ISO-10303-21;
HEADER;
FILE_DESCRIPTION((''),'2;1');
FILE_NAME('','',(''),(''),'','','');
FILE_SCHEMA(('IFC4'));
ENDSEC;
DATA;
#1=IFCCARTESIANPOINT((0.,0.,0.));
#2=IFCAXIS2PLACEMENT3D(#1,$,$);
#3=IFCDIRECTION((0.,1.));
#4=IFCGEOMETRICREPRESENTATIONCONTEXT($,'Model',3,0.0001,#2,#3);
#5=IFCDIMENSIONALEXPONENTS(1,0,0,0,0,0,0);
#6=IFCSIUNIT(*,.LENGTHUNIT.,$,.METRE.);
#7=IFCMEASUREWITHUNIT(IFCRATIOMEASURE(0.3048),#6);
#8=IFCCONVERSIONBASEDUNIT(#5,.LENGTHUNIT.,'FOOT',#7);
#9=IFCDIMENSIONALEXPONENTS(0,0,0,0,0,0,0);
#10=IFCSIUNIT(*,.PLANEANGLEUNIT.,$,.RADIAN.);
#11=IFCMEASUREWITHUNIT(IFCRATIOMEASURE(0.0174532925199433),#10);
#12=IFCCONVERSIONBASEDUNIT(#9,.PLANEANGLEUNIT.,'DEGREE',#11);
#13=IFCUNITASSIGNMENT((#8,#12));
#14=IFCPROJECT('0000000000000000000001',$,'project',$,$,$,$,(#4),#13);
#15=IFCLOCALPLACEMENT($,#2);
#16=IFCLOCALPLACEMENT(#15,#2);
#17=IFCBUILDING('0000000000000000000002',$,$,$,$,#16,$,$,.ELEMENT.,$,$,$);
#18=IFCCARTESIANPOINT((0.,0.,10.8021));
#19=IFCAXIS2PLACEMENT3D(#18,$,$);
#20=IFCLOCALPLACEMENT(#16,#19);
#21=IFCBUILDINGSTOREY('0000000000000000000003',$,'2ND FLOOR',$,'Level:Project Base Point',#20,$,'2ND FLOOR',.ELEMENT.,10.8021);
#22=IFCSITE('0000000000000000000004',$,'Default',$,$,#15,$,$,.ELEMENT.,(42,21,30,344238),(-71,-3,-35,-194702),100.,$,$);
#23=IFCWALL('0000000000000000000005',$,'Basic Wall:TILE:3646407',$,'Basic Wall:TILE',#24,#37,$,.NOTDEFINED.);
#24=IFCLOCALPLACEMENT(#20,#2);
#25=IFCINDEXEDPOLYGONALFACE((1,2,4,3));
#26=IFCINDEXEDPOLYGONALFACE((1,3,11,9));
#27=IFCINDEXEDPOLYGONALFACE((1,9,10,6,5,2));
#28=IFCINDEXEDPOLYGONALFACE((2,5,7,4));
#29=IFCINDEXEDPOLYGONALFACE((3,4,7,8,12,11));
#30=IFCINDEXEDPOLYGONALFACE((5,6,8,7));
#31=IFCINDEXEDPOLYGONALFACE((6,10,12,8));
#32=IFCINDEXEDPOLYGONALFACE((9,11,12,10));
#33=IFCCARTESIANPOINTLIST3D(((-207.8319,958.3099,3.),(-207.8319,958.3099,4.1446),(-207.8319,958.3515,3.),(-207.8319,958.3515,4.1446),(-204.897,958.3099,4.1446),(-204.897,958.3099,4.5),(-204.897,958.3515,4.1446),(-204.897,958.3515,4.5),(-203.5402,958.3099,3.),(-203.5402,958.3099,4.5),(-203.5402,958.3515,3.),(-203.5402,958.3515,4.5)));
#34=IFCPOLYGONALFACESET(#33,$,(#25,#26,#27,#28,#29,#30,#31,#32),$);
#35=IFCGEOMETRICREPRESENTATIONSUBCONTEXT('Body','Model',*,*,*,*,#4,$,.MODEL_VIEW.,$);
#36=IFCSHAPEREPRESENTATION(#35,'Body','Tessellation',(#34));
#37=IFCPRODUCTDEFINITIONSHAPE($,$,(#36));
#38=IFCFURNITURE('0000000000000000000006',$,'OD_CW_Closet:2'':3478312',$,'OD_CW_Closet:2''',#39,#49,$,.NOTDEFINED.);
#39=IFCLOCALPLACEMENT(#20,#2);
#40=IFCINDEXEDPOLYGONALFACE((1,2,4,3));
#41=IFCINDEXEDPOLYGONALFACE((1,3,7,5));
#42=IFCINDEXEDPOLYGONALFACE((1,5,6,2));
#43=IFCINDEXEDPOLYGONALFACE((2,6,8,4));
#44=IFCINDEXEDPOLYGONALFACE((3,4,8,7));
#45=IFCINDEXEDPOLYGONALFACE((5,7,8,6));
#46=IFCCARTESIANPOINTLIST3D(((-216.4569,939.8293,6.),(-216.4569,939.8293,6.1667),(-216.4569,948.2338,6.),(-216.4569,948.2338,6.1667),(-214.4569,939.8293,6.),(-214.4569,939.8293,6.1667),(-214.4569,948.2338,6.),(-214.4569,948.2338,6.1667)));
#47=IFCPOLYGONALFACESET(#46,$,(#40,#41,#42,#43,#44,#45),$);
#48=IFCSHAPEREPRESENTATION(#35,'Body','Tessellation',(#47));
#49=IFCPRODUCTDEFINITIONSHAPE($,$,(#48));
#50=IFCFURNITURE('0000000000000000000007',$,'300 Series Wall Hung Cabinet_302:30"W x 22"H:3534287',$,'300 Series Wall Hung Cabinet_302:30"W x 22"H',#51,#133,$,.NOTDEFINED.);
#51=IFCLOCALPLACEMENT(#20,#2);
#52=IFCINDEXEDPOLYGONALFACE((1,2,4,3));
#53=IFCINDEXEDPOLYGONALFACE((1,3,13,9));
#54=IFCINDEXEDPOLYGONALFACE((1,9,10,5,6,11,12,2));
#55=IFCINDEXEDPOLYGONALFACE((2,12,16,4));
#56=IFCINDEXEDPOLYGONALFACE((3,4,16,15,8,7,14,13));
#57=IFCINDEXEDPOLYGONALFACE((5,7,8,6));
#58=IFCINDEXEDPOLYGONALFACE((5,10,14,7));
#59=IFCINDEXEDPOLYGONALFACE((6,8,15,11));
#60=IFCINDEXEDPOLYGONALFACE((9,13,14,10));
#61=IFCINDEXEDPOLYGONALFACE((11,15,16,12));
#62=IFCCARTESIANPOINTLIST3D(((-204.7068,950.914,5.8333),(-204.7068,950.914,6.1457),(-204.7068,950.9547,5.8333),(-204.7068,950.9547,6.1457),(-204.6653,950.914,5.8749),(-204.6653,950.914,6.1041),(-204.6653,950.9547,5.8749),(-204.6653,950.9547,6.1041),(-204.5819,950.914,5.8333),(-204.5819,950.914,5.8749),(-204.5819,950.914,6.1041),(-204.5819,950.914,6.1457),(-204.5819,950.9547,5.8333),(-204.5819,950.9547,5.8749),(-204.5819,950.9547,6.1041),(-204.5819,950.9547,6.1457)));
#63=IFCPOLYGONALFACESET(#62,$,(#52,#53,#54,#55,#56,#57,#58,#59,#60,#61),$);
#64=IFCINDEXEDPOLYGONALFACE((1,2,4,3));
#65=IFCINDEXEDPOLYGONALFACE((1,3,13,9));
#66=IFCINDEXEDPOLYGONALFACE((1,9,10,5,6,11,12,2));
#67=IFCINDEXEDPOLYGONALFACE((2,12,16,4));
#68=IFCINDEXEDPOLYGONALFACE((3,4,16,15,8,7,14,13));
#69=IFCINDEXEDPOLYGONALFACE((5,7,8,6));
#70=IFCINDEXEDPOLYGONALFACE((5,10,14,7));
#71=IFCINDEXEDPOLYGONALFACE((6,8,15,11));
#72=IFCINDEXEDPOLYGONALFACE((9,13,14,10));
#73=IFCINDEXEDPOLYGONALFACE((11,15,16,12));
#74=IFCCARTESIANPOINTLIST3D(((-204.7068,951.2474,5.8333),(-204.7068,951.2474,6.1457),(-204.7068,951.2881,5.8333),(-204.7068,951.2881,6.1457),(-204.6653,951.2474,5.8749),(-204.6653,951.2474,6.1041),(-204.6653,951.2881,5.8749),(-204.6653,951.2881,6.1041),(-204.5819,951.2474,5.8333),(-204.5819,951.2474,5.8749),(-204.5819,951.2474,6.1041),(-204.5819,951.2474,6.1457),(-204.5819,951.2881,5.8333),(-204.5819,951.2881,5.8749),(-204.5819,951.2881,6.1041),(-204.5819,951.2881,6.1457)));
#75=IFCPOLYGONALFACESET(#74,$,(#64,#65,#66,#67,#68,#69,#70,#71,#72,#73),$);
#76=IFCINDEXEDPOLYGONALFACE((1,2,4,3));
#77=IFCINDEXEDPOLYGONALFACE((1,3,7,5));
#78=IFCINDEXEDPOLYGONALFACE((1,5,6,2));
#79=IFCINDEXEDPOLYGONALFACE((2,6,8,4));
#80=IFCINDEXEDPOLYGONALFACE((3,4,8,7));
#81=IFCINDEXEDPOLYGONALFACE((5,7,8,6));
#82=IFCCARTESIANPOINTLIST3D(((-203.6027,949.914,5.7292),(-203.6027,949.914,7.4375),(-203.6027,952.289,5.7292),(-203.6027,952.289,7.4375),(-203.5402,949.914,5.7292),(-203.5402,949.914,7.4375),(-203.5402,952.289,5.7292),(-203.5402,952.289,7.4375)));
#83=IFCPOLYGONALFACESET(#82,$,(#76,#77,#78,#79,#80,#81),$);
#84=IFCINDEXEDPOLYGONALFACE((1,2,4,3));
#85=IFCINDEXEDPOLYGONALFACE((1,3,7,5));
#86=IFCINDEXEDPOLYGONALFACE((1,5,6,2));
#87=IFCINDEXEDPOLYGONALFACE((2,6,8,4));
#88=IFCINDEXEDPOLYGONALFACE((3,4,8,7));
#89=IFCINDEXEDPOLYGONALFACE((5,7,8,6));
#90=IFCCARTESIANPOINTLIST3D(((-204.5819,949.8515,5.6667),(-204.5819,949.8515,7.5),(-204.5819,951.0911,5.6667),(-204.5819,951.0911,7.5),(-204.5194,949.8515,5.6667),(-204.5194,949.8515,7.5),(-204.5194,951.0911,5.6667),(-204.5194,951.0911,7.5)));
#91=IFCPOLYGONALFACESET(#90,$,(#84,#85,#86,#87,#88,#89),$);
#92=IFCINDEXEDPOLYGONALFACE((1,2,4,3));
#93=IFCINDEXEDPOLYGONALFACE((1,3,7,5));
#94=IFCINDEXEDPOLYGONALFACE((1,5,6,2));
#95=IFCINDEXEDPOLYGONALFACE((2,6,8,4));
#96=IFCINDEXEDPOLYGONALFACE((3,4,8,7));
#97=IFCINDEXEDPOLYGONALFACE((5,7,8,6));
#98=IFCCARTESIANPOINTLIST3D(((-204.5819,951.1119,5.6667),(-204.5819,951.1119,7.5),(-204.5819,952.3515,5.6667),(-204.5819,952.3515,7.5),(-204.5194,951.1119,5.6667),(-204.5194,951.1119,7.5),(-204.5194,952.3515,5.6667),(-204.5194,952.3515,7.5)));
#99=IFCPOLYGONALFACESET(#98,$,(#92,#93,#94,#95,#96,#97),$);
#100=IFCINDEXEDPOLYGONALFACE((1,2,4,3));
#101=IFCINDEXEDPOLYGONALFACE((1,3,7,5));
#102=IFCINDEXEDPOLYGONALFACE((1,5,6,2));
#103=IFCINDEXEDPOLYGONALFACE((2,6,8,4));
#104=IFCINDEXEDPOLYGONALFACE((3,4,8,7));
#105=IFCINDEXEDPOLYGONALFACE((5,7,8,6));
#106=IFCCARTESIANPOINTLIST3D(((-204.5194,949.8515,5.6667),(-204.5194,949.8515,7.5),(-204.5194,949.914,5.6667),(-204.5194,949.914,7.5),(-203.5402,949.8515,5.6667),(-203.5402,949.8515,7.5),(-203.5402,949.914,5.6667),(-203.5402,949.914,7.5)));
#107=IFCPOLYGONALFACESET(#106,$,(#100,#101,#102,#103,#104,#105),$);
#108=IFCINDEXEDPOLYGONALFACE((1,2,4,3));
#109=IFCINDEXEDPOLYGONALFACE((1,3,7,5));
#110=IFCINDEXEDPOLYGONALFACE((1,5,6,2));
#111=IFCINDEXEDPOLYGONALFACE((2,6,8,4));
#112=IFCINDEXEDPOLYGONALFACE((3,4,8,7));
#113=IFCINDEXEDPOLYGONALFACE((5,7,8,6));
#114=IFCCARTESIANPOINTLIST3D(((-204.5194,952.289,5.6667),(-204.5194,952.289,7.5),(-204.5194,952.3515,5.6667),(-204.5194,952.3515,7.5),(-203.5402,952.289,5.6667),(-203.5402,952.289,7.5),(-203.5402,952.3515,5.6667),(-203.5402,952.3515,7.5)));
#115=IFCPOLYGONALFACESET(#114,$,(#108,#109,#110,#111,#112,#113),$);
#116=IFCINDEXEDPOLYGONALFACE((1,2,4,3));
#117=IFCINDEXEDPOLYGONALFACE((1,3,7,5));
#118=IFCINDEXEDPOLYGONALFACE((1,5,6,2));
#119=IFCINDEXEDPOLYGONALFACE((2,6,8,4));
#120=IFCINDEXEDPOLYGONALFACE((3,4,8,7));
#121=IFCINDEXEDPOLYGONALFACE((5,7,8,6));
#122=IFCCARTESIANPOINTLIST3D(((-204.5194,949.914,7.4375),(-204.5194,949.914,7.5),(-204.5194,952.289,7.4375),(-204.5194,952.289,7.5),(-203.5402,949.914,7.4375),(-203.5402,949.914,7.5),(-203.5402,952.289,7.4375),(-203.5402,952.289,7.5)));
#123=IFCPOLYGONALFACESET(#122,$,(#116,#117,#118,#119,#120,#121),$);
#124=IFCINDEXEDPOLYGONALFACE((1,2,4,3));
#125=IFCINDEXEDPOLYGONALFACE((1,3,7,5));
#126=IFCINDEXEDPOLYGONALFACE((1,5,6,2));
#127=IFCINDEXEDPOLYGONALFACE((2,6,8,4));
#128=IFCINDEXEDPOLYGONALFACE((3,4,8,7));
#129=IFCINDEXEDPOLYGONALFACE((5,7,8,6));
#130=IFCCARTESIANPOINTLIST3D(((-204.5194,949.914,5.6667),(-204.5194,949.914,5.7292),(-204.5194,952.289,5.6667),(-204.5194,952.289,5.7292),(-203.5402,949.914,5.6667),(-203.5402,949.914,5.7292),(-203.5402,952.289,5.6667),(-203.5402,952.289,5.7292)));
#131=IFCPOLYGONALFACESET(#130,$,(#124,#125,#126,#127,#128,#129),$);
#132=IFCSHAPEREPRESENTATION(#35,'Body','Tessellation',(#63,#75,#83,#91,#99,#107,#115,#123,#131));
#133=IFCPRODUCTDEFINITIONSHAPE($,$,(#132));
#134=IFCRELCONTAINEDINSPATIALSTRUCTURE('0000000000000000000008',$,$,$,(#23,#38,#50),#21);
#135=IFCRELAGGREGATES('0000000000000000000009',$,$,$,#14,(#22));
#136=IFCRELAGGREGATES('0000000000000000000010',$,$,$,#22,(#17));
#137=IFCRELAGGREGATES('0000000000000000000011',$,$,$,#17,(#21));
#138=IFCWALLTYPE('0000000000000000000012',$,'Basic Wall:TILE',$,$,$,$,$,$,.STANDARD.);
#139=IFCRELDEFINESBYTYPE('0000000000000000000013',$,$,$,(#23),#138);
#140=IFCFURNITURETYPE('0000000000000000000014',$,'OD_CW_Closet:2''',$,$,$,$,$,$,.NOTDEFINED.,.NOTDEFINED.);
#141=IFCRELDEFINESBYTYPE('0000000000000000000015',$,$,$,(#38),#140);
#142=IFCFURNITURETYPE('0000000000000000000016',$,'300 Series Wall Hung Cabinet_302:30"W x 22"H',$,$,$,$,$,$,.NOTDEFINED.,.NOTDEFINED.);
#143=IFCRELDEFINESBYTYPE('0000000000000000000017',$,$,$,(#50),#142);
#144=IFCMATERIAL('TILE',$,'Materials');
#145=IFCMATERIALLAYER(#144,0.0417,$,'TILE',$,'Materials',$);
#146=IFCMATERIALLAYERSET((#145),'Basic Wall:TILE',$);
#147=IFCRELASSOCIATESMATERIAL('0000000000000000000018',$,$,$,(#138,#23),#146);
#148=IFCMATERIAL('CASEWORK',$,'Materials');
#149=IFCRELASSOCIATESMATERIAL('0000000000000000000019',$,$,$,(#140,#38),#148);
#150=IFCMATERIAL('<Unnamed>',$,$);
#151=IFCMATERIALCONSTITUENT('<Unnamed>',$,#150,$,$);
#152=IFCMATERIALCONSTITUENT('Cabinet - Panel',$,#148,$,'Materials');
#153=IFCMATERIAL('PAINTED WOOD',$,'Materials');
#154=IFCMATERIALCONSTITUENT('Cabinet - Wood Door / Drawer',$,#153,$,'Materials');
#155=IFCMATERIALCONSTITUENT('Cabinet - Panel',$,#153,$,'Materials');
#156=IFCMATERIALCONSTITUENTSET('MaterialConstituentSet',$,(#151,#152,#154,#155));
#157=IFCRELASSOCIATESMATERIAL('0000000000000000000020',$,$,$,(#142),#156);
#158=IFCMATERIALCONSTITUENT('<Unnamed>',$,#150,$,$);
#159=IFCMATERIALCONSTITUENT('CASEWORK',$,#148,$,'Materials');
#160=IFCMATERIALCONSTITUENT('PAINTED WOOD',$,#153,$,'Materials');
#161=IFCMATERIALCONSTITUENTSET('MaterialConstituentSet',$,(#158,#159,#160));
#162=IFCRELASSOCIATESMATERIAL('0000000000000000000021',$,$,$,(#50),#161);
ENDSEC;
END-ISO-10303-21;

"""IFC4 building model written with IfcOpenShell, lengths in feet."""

from ifc_helpers import new_model, entity, si_unit, converted_unit, direction, frame, frame_2d, origin, origin_2d_with_axis, place, context, subcontext, project, spatial, polyline, rectangle, outline, extrude, source, transform, mapped, material, layer, layer_set, layer_usage, constituent, constituent_set, type_object, type_shapes, element, save


model = new_model("IFC4")

# Units and contexts
model_context = context("Model", 3, precision=0.0001, world=origin(), true_north=direction((0.0, 1.0)))
body_context = subcontext(model_context, "Body", "Model", "MODEL_VIEW")
ifc_project = project(units=[converted_unit("LENGTHUNIT", "FOOT", entity("IfcRatioMeasure", 0.3048), si_unit("LENGTHUNIT", "METRE"), dimensions=[1, 0, 0, 0, 0, 0, 0]), converted_unit("PLANEANGLEUNIT", "DEGREE", entity("IfcRatioMeasure", 0.0174532925199433), si_unit("PLANEANGLEUNIT", "RADIAN"), dimensions=[0, 0, 0, 0, 0, 0, 0])], contexts=[model_context])

# Site, building, storey
site_placement = place(None, origin())
site = spatial("IfcSite", under=ifc_project, at=site_placement, Name="Default", CompositionType="ELEMENT", RefLatitude=(42, 21, 30, 344238), RefLongitude=(-71, -3, -35, -194702), RefElevation=100.0)
building_placement = place(site_placement, origin())
building = spatial("IfcBuilding", under=site, at=building_placement, CompositionType="ELEMENT")
storey_placement = place(building_placement, frame((0.0, 0.0, 10.8021)))
storey = spatial("IfcBuildingStorey", under=building, at=storey_placement, Name="2ND FLOOR", ObjectType="Level:Project Base Point", LongName="2ND FLOOR", CompositionType="ELEMENT", Elevation=10.8021)

# Shared definitions
ifc_material_1 = material(Name="TILE", Category="Materials")
ifc_layer_1 = layer(ifc_material_1, 0.0417, Name="TILE", Category="Materials")
ifc_layer_set_1 = layer_set([ifc_layer_1], Name="Basic Wall:TILE")
wall_type_1 = type_object("IfcWallType", Name="Basic Wall:TILE", PredefinedType="STANDARD", material=ifc_layer_set_1)

# Wall, opening
ifc_layer_usage_1 = layer_usage(ifc_layer_set_1, "AXIS2", "POSITIVE", -0.0208)
wall_1_placement = place(storey_placement, frame((-203.5402, 958.3307, 3.0), z_axis=(0.0, 0.0, 1.0), x_axis=(-1.0, 0.0, 0.0)))
wall_1 = element("IfcWall", 1, at=wall_1_placement, inside=storey, type_object=wall_type_1, material=ifc_layer_usage_1, Name="Basic Wall:TILE:3646407", ObjectType="Basic Wall:TILE", PredefinedType="NOTDEFINED", context=body_context, shape_type="SweptSolid", body=[
    extrude(rectangle(XDim=4.2917, YDim=0.0417, at=frame_2d((2.1458, 0.0), x_axis=(-1.0, 0.0))), origin(), (0.0, 0.0, 1.0), 1.5),
])
opening_1_placement = place(wall_1_placement, origin())
element("IfcOpeningElement", 2, at=opening_1_placement, cuts=wall_1, PredefinedType="OPENING", context=body_context, shape_type="SweptSolid", body=[
    extrude(rectangle(XDim=0.3554, YDim=2.9349, at=frame_2d((0.0, 0.0), x_axis=(1.0, 0.0))), frame((2.8242, 0.0208, 1.3223), z_axis=(0.0, -1.0, 0.0), x_axis=(0.0, 0.0, 1.0)), (0.0, 0.0, 1.0), 0.0417),
])

# Furniture
ifc_material_2 = material(Name="CASEWORK", Category="Materials")
furniture_type_1 = type_object("IfcFurnitureType", Name="OD_CW_Closet:2'", AssemblyPlace="NOTDEFINED", PredefinedType="NOTDEFINED", material=ifc_material_2)
shared_shape_1 = source(origin(), body_context, "Body", "SweptSolid", [
    extrude(rectangle(XDim=2.0, YDim=8.4045, at=frame_2d((0.0, 0.0), x_axis=(1.0, 0.0))), frame((4.2022, 1.0, 0.0), z_axis=(0.0, 0.0, 1.0), x_axis=(0.0, -1.0, 0.0)), (0.0, 0.0, 1.0), 0.1667),
])
type_shapes(furniture_type_1, [shared_shape_1])
furniture_1_placement = place(storey_placement, frame((-216.4569, 948.2338, 6.0), z_axis=(0.0, 0.0, 1.0), x_axis=(0.0, -1.0, 0.0)))
element("IfcFurniture", 3, at=furniture_1_placement, inside=storey, type_object=furniture_type_1, material=ifc_material_2, Name="OD_CW_Closet:2':3478312", ObjectType="OD_CW_Closet:2'", PredefinedType="NOTDEFINED", context=body_context, shape_type="MappedRepresentation", body=[
    mapped(shared_shape_1, transform((0.0, 0.0, 0.0), scale=1.0)),
])
ifc_material_3 = material(Name="<Unnamed>")
ifc_constituent_1 = constituent(ifc_material_3, Name="<Unnamed>")
ifc_constituent_2 = constituent(ifc_material_2, Name="CASEWORK", Category="Materials")
ifc_material_4 = material(Name="PAINTED WOOD", Category="Materials")
ifc_constituent_3 = constituent(ifc_material_4, Name="PAINTED WOOD", Category="Materials")
ifc_constituent_set_1 = constituent_set(constituents=[ifc_constituent_1, ifc_constituent_2, ifc_constituent_3], Name="MaterialConstituentSet")
ifc_constituent_4 = constituent(ifc_material_3, Name="<Unnamed>")
ifc_constituent_5 = constituent(ifc_material_2, Name="Cabinet - Panel", Category="Materials")
ifc_constituent_6 = constituent(ifc_material_4, Name="Cabinet - Wood Door / Drawer", Category="Materials")
ifc_constituent_7 = constituent(ifc_material_4, Name="Cabinet - Panel", Category="Materials")
ifc_constituent_set_2 = constituent_set(constituents=[ifc_constituent_4, ifc_constituent_5, ifc_constituent_6, ifc_constituent_7], Name="MaterialConstituentSet")
furniture_type_2 = type_object("IfcFurnitureType", Name="300 Series Wall Hung Cabinet_302:30\"W x 22\"H", AssemblyPlace="NOTDEFINED", PredefinedType="NOTDEFINED", material=ifc_constituent_set_2)
shared_shape_2 = source(origin(), body_context, "Body", "SweptSolid", [
    extrude(outline(polyline([(-0.0521, -0.1146), (-0.0521, -0.1562), (0.0729, -0.1562), (0.0729, 0.1562), (-0.0521, 0.1562), (-0.0521, 0.1146), (0.0313, 0.1146), (0.0313, -0.1146), (-0.0521, -0.1146)])), frame((1.0625, 1.0937, 0.3229), z_axis=(-1.0, 0.0, 0.0), x_axis=(0.0, 1.0, 0.0)), (0.0, 0.0, -1.0), 0.0407),
    extrude(outline(polyline([(-0.0521, -0.1146), (-0.0521, -0.1562), (0.0729, -0.1562), (0.0729, 0.1562), (-0.0521, 0.1562), (-0.0521, 0.1146), (0.0313, 0.1146), (0.0313, -0.1146), (-0.0521, -0.1146)])), frame((1.3958, 1.0937, 0.3229), z_axis=(-1.0, 0.0, 0.0), x_axis=(0.0, 1.0, 0.0)), (0.0, 0.0, -1.0), 0.0407),
    extrude(rectangle(XDim=0.0625, YDim=2.375, at=frame_2d((0.0, 0.0), x_axis=(1.0, 0.0))), frame((1.25, 0.0313, 0.0625), z_axis=(0.0, 0.0, 1.0), x_axis=(0.0, 1.0, 0.0)), (0.0, 0.0, 1.0), 1.7083),
    extrude(rectangle(XDim=0.0625, YDim=1.2396, at=origin_2d_with_axis()), frame((0.6198, 1.0104, 0.0), z_axis=(0.0, 0.0, 1.0), x_axis=(0.0, 1.0, 0.0)), (0.0, 0.0, 1.0), 1.8333),
    extrude(rectangle(XDim=0.0625, YDim=1.2396, at=frame_2d((0.0, 0.0), x_axis=(1.0, 0.0))), frame((1.8802, 1.0104, 0.0), z_axis=(0.0, 0.0, 1.0), x_axis=(0.0, 1.0, 0.0)), (0.0, 0.0, 1.0), 1.8333),
    extrude(rectangle(XDim=0.0625, YDim=0.9792, at=frame_2d((0.0, 0.0), x_axis=(1.0, 0.0))), frame((0.0313, 0.4896, 0.0)), (0.0, 0.0, 1.0), 1.8333),
    extrude(rectangle(XDim=0.0625, YDim=0.9792, at=frame_2d((0.0, 0.0), x_axis=(1.0, 0.0))), frame((2.4688, 0.4896, 0.0)), (0.0, 0.0, 1.0), 1.8333),
    extrude(rectangle(XDim=2.375, YDim=0.9792, at=frame_2d((0.0, 0.0), x_axis=(1.0, 0.0))), frame((1.25, 0.4896, 1.7708), z_axis=(0.0, 0.0, 1.0), x_axis=(-1.0, 0.0, 0.0)), (0.0, 0.0, 1.0), 0.0625),
    extrude(rectangle(XDim=2.375, YDim=0.9792, at=frame_2d((0.0, 0.0), x_axis=(1.0, 0.0))), frame((1.25, 0.4896, 0.0), z_axis=(0.0, 0.0, 1.0), x_axis=(-1.0, 0.0, 0.0)), (0.0, 0.0, 1.0), 0.0625),
])
type_shapes(furniture_type_2, [shared_shape_2])
furniture_2_placement = place(storey_placement, frame((-203.5402, 949.8515, 5.6667), z_axis=(0.0, 0.0, 1.0), x_axis=(0.0, 1.0, 0.0)))
element("IfcFurniture", 4, at=furniture_2_placement, inside=storey, type_object=furniture_type_2, material=ifc_constituent_set_1, Name="300 Series Wall Hung Cabinet_302:30\"W x 22\"H:3534287", ObjectType="300 Series Wall Hung Cabinet_302:30\"W x 22\"H", PredefinedType="NOTDEFINED", context=body_context, shape_type="MappedRepresentation", body=[
    mapped(shared_shape_2, transform((0.0, 0.0, 0.0), scale=1.0)),
])

save(model, "model.ifc")
